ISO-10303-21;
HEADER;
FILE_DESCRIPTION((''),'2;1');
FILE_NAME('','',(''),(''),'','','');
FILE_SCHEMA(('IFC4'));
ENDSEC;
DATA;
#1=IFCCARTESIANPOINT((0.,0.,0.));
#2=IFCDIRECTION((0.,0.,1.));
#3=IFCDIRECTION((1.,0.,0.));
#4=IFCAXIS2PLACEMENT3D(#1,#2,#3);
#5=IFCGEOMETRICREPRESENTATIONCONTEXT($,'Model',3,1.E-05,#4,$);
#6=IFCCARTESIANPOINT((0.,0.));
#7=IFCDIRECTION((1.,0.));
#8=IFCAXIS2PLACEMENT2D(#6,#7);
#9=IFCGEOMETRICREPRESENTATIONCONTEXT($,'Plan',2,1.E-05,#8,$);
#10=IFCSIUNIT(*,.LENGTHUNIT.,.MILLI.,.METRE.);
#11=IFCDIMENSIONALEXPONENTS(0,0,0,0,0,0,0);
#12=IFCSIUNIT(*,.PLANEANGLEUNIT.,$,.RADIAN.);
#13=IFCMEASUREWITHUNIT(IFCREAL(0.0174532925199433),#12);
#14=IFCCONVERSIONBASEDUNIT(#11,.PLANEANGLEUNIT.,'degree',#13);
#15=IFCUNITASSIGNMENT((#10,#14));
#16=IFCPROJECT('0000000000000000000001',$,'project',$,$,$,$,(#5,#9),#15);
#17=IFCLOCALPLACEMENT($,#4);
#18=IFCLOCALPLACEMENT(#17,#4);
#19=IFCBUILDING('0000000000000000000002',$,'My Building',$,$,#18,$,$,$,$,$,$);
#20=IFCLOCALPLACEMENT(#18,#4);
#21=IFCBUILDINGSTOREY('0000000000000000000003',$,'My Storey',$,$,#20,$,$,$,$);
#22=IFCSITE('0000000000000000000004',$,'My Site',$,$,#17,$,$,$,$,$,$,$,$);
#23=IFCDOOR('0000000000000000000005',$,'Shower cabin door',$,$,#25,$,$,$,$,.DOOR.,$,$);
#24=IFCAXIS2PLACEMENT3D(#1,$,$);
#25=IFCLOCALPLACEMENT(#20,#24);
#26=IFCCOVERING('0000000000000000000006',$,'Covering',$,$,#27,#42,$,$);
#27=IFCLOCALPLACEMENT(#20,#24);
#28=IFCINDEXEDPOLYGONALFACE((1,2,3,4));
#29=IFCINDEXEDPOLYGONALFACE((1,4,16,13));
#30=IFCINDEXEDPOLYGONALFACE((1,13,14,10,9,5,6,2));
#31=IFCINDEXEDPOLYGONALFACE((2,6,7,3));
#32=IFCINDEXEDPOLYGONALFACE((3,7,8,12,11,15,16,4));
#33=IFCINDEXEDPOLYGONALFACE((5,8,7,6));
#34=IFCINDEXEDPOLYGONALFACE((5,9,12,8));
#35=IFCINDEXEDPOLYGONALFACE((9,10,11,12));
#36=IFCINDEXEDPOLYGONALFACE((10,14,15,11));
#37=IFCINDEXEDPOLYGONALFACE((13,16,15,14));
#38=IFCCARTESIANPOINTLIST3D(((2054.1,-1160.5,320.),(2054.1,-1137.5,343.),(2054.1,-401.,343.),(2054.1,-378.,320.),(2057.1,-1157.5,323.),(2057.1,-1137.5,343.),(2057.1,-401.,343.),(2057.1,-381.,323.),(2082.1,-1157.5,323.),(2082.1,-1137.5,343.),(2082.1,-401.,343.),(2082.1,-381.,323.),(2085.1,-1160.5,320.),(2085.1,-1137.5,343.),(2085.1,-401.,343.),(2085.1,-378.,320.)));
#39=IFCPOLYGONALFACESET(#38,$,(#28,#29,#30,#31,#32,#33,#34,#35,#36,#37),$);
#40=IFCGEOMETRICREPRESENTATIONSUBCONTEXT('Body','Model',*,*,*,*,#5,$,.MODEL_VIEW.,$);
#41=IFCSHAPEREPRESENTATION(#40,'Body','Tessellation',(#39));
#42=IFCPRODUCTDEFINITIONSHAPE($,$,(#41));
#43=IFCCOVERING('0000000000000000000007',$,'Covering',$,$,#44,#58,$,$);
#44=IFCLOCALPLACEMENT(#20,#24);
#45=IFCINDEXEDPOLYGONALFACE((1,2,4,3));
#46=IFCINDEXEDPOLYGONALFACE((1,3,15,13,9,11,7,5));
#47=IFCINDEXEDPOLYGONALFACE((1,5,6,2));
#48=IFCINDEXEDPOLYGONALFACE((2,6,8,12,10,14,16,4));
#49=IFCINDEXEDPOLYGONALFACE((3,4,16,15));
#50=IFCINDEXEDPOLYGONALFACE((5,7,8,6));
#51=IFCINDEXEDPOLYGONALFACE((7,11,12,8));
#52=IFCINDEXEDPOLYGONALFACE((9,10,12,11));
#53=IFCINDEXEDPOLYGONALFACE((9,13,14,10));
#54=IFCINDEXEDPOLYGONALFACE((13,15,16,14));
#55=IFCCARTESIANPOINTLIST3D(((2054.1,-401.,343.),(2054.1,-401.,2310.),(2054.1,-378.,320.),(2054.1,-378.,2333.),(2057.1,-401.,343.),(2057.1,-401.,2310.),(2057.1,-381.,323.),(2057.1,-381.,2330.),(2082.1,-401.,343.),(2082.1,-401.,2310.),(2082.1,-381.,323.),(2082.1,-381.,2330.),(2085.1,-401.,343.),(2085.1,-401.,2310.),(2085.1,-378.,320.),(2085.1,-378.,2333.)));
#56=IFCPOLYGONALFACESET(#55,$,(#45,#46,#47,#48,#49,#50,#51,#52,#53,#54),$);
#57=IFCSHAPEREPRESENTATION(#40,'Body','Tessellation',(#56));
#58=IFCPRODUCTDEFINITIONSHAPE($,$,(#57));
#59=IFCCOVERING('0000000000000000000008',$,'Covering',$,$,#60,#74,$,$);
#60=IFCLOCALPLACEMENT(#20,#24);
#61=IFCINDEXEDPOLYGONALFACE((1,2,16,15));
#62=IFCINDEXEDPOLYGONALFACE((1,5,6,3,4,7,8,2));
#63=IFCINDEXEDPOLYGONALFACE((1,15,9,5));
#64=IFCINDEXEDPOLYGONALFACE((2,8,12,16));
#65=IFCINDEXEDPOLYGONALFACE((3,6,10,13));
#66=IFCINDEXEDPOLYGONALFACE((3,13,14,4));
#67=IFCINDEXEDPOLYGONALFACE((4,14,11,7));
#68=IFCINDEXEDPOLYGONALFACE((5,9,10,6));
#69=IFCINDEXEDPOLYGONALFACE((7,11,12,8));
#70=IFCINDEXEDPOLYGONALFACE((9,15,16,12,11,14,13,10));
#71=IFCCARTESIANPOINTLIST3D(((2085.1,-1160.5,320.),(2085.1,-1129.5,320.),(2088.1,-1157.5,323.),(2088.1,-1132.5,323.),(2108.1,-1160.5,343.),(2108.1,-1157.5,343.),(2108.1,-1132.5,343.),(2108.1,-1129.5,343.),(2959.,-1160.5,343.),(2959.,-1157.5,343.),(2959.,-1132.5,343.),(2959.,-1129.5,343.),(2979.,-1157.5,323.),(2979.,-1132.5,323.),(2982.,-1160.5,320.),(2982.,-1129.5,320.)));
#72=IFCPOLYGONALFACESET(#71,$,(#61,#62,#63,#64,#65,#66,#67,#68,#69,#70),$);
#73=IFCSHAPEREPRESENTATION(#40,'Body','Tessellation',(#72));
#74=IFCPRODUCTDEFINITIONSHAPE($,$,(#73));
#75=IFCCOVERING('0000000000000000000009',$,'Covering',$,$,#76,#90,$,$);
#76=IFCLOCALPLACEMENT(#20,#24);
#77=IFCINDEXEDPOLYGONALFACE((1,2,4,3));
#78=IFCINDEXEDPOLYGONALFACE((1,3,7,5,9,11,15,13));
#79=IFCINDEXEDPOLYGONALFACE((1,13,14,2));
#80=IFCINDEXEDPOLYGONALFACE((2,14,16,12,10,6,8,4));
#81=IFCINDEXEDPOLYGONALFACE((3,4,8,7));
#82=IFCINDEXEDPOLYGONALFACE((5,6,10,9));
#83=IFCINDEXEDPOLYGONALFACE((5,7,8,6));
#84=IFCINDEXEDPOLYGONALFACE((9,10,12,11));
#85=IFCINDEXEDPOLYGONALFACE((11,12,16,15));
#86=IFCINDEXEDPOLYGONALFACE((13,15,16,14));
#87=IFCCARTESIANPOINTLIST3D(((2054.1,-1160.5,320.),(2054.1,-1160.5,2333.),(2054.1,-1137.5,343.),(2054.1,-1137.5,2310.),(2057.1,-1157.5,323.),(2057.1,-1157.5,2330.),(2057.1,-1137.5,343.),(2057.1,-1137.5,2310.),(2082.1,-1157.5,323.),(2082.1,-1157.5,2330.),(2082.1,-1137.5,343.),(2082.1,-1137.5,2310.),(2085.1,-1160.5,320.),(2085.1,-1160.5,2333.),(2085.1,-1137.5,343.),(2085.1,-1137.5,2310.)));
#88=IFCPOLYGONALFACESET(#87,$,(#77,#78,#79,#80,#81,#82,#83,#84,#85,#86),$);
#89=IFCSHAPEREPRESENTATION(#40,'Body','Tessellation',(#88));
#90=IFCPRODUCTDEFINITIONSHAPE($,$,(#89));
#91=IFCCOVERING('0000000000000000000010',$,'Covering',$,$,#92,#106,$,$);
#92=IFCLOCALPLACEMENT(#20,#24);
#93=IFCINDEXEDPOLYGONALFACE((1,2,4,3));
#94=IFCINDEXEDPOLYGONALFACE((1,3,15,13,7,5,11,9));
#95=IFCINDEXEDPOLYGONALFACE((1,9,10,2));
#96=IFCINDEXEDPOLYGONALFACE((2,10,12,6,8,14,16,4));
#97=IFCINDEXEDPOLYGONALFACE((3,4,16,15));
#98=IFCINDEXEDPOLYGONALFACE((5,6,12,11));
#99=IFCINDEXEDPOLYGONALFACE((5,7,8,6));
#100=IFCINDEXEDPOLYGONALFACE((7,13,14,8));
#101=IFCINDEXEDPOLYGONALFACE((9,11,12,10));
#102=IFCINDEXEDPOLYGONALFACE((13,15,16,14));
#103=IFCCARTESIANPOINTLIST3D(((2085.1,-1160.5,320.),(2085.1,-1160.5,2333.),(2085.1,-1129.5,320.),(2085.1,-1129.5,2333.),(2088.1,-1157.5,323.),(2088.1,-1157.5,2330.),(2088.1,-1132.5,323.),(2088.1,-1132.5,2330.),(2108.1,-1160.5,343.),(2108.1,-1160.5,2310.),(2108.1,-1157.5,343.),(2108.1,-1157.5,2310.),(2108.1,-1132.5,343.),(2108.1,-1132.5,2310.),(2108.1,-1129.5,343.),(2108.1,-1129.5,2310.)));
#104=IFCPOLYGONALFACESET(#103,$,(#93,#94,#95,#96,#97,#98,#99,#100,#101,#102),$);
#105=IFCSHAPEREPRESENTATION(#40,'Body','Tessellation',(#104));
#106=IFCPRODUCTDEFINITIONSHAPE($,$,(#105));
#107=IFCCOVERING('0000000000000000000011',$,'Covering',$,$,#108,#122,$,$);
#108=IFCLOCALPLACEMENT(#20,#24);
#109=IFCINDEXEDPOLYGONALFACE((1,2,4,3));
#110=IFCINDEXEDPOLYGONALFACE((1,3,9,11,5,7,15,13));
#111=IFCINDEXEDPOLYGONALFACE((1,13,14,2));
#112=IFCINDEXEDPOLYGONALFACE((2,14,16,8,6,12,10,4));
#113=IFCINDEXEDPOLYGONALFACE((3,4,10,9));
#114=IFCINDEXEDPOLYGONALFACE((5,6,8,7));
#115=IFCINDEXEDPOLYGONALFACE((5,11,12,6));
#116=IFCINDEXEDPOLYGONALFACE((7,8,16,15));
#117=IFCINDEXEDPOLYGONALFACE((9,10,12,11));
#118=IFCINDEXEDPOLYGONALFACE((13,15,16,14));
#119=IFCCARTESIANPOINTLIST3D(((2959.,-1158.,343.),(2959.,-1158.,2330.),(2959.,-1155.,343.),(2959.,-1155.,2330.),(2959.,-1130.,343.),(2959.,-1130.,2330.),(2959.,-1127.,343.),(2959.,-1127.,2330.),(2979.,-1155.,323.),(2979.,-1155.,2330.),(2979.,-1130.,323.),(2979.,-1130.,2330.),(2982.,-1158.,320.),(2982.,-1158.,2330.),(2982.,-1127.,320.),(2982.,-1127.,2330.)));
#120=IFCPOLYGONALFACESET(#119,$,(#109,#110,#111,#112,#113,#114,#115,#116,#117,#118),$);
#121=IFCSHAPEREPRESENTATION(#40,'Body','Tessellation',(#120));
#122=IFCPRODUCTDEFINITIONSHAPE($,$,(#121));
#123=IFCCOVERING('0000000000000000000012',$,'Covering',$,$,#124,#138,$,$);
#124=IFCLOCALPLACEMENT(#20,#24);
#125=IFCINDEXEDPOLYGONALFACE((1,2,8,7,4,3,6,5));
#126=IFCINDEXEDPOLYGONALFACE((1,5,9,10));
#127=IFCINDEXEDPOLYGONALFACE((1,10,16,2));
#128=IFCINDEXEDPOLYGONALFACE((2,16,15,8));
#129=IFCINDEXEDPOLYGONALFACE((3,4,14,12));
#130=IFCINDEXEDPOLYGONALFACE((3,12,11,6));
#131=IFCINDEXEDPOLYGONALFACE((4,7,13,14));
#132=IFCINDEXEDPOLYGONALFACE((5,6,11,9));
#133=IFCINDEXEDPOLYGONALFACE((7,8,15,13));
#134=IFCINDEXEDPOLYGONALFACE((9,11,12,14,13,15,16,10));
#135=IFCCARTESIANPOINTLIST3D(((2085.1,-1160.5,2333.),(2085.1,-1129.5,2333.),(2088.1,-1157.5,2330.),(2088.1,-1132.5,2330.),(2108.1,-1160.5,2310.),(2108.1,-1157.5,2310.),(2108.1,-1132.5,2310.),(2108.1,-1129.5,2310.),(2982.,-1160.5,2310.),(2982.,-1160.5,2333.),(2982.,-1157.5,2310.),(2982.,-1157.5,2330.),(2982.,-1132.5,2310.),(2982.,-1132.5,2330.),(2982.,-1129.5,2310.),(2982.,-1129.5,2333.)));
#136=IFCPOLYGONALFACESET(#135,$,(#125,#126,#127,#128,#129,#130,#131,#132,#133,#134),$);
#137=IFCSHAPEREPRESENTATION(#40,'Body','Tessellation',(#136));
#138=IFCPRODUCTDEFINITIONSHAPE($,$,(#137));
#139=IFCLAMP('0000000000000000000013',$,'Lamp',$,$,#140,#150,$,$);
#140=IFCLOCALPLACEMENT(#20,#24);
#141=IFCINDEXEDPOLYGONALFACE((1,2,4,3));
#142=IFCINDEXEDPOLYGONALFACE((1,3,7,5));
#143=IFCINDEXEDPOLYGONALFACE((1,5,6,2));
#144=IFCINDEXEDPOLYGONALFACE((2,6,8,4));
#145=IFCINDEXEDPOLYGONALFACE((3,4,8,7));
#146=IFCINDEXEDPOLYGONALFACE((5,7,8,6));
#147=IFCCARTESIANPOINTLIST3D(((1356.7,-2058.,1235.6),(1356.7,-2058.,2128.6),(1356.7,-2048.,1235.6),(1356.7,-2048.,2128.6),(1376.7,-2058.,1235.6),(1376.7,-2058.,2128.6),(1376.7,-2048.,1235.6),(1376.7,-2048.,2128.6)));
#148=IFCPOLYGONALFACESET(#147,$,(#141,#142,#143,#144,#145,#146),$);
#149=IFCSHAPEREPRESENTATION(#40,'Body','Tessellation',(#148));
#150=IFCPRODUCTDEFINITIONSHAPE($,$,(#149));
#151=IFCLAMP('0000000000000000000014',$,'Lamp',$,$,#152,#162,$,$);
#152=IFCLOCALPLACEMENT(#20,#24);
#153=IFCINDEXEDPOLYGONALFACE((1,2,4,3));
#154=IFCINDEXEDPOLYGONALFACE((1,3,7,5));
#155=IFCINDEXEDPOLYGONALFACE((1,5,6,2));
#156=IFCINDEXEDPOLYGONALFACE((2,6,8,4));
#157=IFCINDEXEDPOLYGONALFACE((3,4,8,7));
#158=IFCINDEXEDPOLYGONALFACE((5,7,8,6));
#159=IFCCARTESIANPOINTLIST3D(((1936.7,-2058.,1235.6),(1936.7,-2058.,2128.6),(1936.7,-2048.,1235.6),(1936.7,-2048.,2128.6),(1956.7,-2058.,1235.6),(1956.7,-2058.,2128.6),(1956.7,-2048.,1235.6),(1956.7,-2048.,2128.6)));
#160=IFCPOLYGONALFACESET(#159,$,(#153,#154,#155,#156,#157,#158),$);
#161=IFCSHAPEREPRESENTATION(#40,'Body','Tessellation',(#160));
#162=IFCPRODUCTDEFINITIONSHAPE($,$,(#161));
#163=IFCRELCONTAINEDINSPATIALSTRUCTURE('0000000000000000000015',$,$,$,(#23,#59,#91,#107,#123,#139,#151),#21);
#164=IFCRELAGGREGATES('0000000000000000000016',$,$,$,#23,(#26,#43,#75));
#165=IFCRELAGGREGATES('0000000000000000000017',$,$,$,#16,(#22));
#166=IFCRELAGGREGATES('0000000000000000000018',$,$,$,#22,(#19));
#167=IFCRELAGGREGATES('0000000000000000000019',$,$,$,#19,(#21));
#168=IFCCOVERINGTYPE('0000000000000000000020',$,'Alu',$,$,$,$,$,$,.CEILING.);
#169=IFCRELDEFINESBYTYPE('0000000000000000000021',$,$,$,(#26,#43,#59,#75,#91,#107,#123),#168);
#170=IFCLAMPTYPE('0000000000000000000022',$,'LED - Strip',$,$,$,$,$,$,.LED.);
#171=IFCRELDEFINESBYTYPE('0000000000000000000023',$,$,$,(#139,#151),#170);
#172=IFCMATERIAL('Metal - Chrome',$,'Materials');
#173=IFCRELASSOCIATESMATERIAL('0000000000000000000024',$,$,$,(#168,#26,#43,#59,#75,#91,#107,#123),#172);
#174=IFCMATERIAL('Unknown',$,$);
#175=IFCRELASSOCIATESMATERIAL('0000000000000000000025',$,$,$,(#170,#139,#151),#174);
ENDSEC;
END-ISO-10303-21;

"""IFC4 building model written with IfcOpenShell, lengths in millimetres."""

from ifc_helpers import new_model, entity, si_unit, converted_unit, frame, origin_with_axes, origin_2d_with_axis, place, context, subcontext, project, spatial, line, indexed_curve, outline, extrude, clip, halfspace, material, material_profile, profile_set, profile_usage, type_object, element, aggregate, save


model = new_model("IFC4")

# Units and contexts
model_context = context("Model", 3, precision=1e-05, world=origin_with_axes())
plan_context = context("Plan", 2, precision=1e-05, world=origin_2d_with_axis())
body_context = subcontext(model_context, "Body", "Model", "MODEL_VIEW")
ifc_project = project(units=[si_unit("LENGTHUNIT", "METRE", prefix="MILLI"), converted_unit("PLANEANGLEUNIT", "degree", entity("IfcReal", 0.0174532925199433), si_unit("PLANEANGLEUNIT", "RADIAN"), dimensions=[0, 0, 0, 0, 0, 0, 0])], contexts=[model_context, plan_context])

# Site, building, storey
site_placement = place(None, origin_with_axes())
site = spatial("IfcSite", under=ifc_project, at=site_placement, Name="My Site")
building_placement = place(site_placement, origin_with_axes())
building = spatial("IfcBuilding", under=site, at=building_placement, Name="My Building")
storey_placement = place(building_placement, origin_with_axes())
storey = spatial("IfcBuildingStorey", under=building, at=storey_placement, Name="My Storey")

# Shared definitions
ifc_material_1 = material(Name="Unknown")

# Door
door_placement = place(storey_placement, frame((2054.1, -378.0, 320.0), z_axis=(0.0, 0.0, 1.0), x_axis=(1.0, 0.0, 0.0)))
door = element("IfcDoor", 1, at=door_placement, inside=storey, Name="Shower cabin door", PredefinedType="DOOR")

# Coverings
ifc_material_2 = material(Name="Metal - Chrome", Category="Materials")
ifc_material_profile_1 = material_profile(ifc_material_2, outline(indexed_curve([(0.0, 0.0), (0.0, 23.0), (3.0, 23.0), (3.0, 3.0), (28.0, 3.0), (28.0, 23.0), (31.0, 23.0), (31.0, 0.0)], segments=[line(1, 8), line(8, 7), line(7, 6), line(6, 5), line(5, 4), line(4, 3), line(3, 2), line(2, 1)], self_intersect=False)))
ifc_profile_set_1 = profile_set([ifc_material_profile_1])
ifc_profile_usage_1 = profile_usage(ifc_profile_set_1, cardinal=5)
covering_type_1 = type_object("IfcCoveringType", Name="Alu", PredefinedType="CEILING", material=ifc_profile_set_1)
covering_1_placement = place(door_placement, frame((0.0, 0.0, 0.0), z_axis=(0.0, -1.0, 0.0), x_axis=(1.0, 0.0, 0.0)))
covering_1 = element("IfcCovering", 2, at=covering_1_placement, type_object=covering_type_1, material=ifc_profile_usage_1, Name="Covering", context=body_context, shape_type="Clipping", body=[
    clip(clip(extrude(outline(indexed_curve([(0.0, 0.0), (0.0, 23.0), (3.0, 23.0), (3.0, 3.0), (28.0, 3.0), (28.0, 23.0), (31.0, 23.0), (31.0, 0.0)], segments=[line(1, 8), line(8, 7), line(7, 6), line(6, 5), line(5, 4), line(4, 3), line(3, 2), line(2, 1)], self_intersect=False)), origin_with_axes(), (0.0, 0.0, 1.0), 782.5), halfspace(frame((-1565.0, 0.0, 782.5), z_axis=(0.0, 0.707107, 0.707107), x_axis=(1.0, 0.0, 0.0)), False)), halfspace(frame((-1565.0, 0.0, 0.0), z_axis=(0.0, 0.707107, -0.707107), x_axis=(1.0, 0.0, 0.0)), False)),
])
ifc_profile_usage_2 = profile_usage(ifc_profile_set_1, cardinal=5)
covering_2_placement = place(door_placement, frame((31.0, 0.0, 0.0), z_axis=(0.0, 0.0, 1.0), x_axis=(-1.0, 0.0, 0.0)))
covering_2 = element("IfcCovering", 3, at=covering_2_placement, type_object=covering_type_1, material=ifc_profile_usage_2, Name="Covering", context=body_context, shape_type="Clipping", body=[
    clip(clip(extrude(outline(indexed_curve([(0.0, 0.0), (0.0, 23.0), (3.0, 23.0), (3.0, 3.0), (28.0, 3.0), (28.0, 23.0), (31.0, 23.0), (31.0, 0.0)], segments=[line(1, 8), line(8, 7), line(7, 6), line(6, 5), line(5, 4), line(4, 3), line(3, 2), line(2, 1)], self_intersect=False)), origin_with_axes(), (0.0, 0.0, 1.0), 2013.0), halfspace(frame((2085.1, 0.0, 2013.0), z_axis=(0.0, 0.707107, 0.707107), x_axis=(1.0, 0.0, 0.0)), False)), halfspace(frame((2085.1, 0.0, 0.0), z_axis=(0.0, 0.707107, -0.707107), x_axis=(1.0, 0.0, 0.0)), False)),
])
ifc_profile_usage_3 = profile_usage(ifc_profile_set_1, cardinal=5)
covering_3_placement = place(storey_placement, frame((2085.1, -1160.5, 320.0), z_axis=(1.0, 0.0, 0.0), x_axis=(0.0, 1.0, 0.0)))
element("IfcCovering", 4, at=covering_3_placement, inside=storey, type_object=covering_type_1, material=ifc_profile_usage_3, Name="Covering", context=body_context, shape_type="Clipping", body=[
    clip(clip(extrude(outline(indexed_curve([(0.0, 0.0), (0.0, 23.0), (3.0, 23.0), (3.0, 3.0), (28.0, 3.0), (28.0, 23.0), (31.0, 23.0), (31.0, 0.0)], segments=[line(1, 8), line(8, 7), line(7, 6), line(6, 5), line(5, 4), line(4, 3), line(3, 2), line(2, 1)], self_intersect=False)), origin_with_axes(), (0.0, 0.0, 1.0), 896.9), halfspace(frame((1160.5, 0.0, 0.0), z_axis=(-0.000001, 0.707107, -0.707107), x_axis=(1.0, 0.000001, 0.0)), False)), halfspace(frame((1160.5, 0.0, 896.9), z_axis=(0.0, 0.707107, 0.707107), x_axis=(1.0, -0.000001, 0.0)), False)),
])
ifc_profile_usage_4 = profile_usage(ifc_profile_set_1, cardinal=5)
covering_4_placement = place(door_placement, frame((0.0, -782.5, 0.0), z_axis=(0.0, 0.0, 1.0), x_axis=(1.0, 0.0, 0.0)))
covering_4 = element("IfcCovering", 5, at=covering_4_placement, type_object=covering_type_1, material=ifc_profile_usage_4, Name="Covering", context=body_context, shape_type="Clipping", body=[
    clip(clip(extrude(outline(indexed_curve([(0.0, 0.0), (0.0, 23.0), (3.0, 23.0), (3.0, 3.0), (28.0, 3.0), (28.0, 23.0), (31.0, 23.0), (31.0, 0.0)], segments=[line(1, 8), line(8, 7), line(7, 6), line(6, 5), line(5, 4), line(4, 3), line(3, 2), line(2, 1)], self_intersect=False)), origin_with_axes(), (0.0, 0.0, 1.0), 2013.0), halfspace(frame((-2054.1, 0.0, 2013.0), z_axis=(0.0, 0.707107, 0.707107), x_axis=(1.0, 0.0, 0.0)), False)), halfspace(frame((-2054.1, 0.0, 0.0), z_axis=(0.0, 0.707107, -0.707107), x_axis=(1.0, 0.0, 0.0)), False)),
])
aggregate(door, [covering_1, covering_2, covering_4])

# Coverings
ifc_profile_usage_5 = profile_usage(ifc_profile_set_1, cardinal=5)
covering_5_placement = place(storey_placement, frame((2085.1, -1129.5, 320.0), z_axis=(0.0, 0.0, 1.0), x_axis=(0.0, -1.0, 0.0)))
element("IfcCovering", 6, at=covering_5_placement, inside=storey, type_object=covering_type_1, material=ifc_profile_usage_5, Name="Covering", context=body_context, shape_type="Clipping", body=[
    clip(clip(extrude(outline(indexed_curve([(0.0, 0.0), (0.0, 23.0), (3.0, 23.0), (3.0, 3.0), (28.0, 3.0), (28.0, 23.0), (31.0, 23.0), (31.0, 0.0)], segments=[line(1, 8), line(8, 7), line(7, 6), line(6, 5), line(5, 4), line(4, 3), line(3, 2), line(2, 1)], self_intersect=False)), origin_with_axes(), (0.0, 0.0, 1.0), 2013.0), halfspace(frame((-1129.5, 0.0, 0.0), z_axis=(0.0, 0.707107, -0.707107), x_axis=(1.0, 0.0, 0.0)), False)), halfspace(frame((-1129.5, 0.0, 2013.0), z_axis=(0.0, 0.707107, 0.707107), x_axis=(1.0, 0.0, 0.0)), False)),
])
ifc_profile_usage_6 = profile_usage(ifc_profile_set_1, cardinal=5)
covering_6_placement = place(storey_placement, frame((2982.0, -1158.0, 320.0), z_axis=(0.0, 0.0, 1.0), x_axis=(-0.000001, 1.0, 0.0)))
element("IfcCovering", 7, at=covering_6_placement, inside=storey, type_object=covering_type_1, material=ifc_profile_usage_6, Name="Covering", context=body_context, shape_type="Clipping", body=[
    clip(extrude(outline(indexed_curve([(0.0, 0.0), (0.0, 23.0), (3.0, 23.0), (3.0, 3.0), (28.0, 3.0), (28.0, 23.0), (31.0, 23.0), (31.0, 0.0)], segments=[line(1, 8), line(8, 7), line(7, 6), line(6, 5), line(5, 4), line(4, 3), line(3, 2), line(2, 1)], self_intersect=False)), origin_with_axes(), (0.0, 0.0, 1.0), 2010.0), halfspace(frame((1158.0, 0.0, 0.0), z_axis=(0.0, 0.707107, -0.707107), x_axis=(1.0, 0.0, 0.0)), False)),
])
ifc_profile_usage_7 = profile_usage(ifc_profile_set_1, cardinal=5)
covering_7_placement = place(storey_placement, frame((2085.1, -1129.5, 2333.0), z_axis=(1.0, 0.0, 0.0), x_axis=(0.0, -1.0, 0.0)))
element("IfcCovering", 8, at=covering_7_placement, inside=storey, type_object=covering_type_1, material=ifc_profile_usage_7, Name="Covering", context=body_context, shape_type="Clipping", body=[
    clip(extrude(outline(indexed_curve([(0.0, 0.0), (0.0, 23.0), (3.0, 23.0), (3.0, 3.0), (28.0, 3.0), (28.0, 23.0), (31.0, 23.0), (31.0, 0.0)], segments=[line(1, 8), line(8, 7), line(7, 6), line(6, 5), line(5, 4), line(4, 3), line(3, 2), line(2, 1)], self_intersect=False)), origin_with_axes(), (0.0, 0.0, 1.0), 896.9), halfspace(frame((-1129.5, 0.0, 0.0), z_axis=(0.0, 0.707107, -0.707107), x_axis=(1.0, 0.0, 0.0)), False)),
])

# Lamps
ifc_material_profile_2 = material_profile(ifc_material_1, outline(indexed_curve([(-10.0, 10.0), (-10.0, 0.0), (10.0, 0.0), (10.0, 10.0)], segments=[line(4, 1), line(1, 2), line(2, 3), line(3, 4)], self_intersect=False)))
ifc_profile_set_2 = profile_set([ifc_material_profile_2])
ifc_profile_usage_8 = profile_usage(ifc_profile_set_2, cardinal=5)
lamp_type = type_object("IfcLampType", Name="LED - Strip", PredefinedType="LED", material=ifc_profile_set_2)
lamp_1_placement = place(storey_placement, frame((1366.7, -2058.0, 1235.6), z_axis=(0.0, 0.0, 1.0), x_axis=(1.0, 0.0, 0.0)))
element("IfcLamp", 9, at=lamp_1_placement, inside=storey, type_object=lamp_type, material=ifc_profile_usage_8, Name="Lamp", context=body_context, shape_type="SweptSolid", body=[
    extrude(outline(indexed_curve([(-10.0, 10.0), (-10.0, 0.0), (10.0, 0.0), (10.0, 10.0)], segments=[line(4, 1), line(1, 2), line(2, 3), line(3, 4)], self_intersect=False)), origin_with_axes(), (0.0, 0.0, 1.0), 892.9),
])
ifc_profile_usage_9 = profile_usage(ifc_profile_set_2, cardinal=5)
lamp_2_placement = place(storey_placement, frame((1946.7, -2058.0, 1235.6), z_axis=(0.0, 0.0, 1.0), x_axis=(1.0, 0.0, 0.0)))
element("IfcLamp", 10, at=lamp_2_placement, inside=storey, type_object=lamp_type, material=ifc_profile_usage_9, Name="Lamp", context=body_context, shape_type="SweptSolid", body=[
    extrude(outline(indexed_curve([(-10.0, 10.0), (-10.0, 0.0), (10.0, 0.0), (10.0, 10.0)], segments=[line(4, 1), line(1, 2), line(2, 3), line(3, 4)], self_intersect=False)), origin_with_axes(), (0.0, 0.0, 1.0), 892.9),
])

save(model, "model.ifc")
